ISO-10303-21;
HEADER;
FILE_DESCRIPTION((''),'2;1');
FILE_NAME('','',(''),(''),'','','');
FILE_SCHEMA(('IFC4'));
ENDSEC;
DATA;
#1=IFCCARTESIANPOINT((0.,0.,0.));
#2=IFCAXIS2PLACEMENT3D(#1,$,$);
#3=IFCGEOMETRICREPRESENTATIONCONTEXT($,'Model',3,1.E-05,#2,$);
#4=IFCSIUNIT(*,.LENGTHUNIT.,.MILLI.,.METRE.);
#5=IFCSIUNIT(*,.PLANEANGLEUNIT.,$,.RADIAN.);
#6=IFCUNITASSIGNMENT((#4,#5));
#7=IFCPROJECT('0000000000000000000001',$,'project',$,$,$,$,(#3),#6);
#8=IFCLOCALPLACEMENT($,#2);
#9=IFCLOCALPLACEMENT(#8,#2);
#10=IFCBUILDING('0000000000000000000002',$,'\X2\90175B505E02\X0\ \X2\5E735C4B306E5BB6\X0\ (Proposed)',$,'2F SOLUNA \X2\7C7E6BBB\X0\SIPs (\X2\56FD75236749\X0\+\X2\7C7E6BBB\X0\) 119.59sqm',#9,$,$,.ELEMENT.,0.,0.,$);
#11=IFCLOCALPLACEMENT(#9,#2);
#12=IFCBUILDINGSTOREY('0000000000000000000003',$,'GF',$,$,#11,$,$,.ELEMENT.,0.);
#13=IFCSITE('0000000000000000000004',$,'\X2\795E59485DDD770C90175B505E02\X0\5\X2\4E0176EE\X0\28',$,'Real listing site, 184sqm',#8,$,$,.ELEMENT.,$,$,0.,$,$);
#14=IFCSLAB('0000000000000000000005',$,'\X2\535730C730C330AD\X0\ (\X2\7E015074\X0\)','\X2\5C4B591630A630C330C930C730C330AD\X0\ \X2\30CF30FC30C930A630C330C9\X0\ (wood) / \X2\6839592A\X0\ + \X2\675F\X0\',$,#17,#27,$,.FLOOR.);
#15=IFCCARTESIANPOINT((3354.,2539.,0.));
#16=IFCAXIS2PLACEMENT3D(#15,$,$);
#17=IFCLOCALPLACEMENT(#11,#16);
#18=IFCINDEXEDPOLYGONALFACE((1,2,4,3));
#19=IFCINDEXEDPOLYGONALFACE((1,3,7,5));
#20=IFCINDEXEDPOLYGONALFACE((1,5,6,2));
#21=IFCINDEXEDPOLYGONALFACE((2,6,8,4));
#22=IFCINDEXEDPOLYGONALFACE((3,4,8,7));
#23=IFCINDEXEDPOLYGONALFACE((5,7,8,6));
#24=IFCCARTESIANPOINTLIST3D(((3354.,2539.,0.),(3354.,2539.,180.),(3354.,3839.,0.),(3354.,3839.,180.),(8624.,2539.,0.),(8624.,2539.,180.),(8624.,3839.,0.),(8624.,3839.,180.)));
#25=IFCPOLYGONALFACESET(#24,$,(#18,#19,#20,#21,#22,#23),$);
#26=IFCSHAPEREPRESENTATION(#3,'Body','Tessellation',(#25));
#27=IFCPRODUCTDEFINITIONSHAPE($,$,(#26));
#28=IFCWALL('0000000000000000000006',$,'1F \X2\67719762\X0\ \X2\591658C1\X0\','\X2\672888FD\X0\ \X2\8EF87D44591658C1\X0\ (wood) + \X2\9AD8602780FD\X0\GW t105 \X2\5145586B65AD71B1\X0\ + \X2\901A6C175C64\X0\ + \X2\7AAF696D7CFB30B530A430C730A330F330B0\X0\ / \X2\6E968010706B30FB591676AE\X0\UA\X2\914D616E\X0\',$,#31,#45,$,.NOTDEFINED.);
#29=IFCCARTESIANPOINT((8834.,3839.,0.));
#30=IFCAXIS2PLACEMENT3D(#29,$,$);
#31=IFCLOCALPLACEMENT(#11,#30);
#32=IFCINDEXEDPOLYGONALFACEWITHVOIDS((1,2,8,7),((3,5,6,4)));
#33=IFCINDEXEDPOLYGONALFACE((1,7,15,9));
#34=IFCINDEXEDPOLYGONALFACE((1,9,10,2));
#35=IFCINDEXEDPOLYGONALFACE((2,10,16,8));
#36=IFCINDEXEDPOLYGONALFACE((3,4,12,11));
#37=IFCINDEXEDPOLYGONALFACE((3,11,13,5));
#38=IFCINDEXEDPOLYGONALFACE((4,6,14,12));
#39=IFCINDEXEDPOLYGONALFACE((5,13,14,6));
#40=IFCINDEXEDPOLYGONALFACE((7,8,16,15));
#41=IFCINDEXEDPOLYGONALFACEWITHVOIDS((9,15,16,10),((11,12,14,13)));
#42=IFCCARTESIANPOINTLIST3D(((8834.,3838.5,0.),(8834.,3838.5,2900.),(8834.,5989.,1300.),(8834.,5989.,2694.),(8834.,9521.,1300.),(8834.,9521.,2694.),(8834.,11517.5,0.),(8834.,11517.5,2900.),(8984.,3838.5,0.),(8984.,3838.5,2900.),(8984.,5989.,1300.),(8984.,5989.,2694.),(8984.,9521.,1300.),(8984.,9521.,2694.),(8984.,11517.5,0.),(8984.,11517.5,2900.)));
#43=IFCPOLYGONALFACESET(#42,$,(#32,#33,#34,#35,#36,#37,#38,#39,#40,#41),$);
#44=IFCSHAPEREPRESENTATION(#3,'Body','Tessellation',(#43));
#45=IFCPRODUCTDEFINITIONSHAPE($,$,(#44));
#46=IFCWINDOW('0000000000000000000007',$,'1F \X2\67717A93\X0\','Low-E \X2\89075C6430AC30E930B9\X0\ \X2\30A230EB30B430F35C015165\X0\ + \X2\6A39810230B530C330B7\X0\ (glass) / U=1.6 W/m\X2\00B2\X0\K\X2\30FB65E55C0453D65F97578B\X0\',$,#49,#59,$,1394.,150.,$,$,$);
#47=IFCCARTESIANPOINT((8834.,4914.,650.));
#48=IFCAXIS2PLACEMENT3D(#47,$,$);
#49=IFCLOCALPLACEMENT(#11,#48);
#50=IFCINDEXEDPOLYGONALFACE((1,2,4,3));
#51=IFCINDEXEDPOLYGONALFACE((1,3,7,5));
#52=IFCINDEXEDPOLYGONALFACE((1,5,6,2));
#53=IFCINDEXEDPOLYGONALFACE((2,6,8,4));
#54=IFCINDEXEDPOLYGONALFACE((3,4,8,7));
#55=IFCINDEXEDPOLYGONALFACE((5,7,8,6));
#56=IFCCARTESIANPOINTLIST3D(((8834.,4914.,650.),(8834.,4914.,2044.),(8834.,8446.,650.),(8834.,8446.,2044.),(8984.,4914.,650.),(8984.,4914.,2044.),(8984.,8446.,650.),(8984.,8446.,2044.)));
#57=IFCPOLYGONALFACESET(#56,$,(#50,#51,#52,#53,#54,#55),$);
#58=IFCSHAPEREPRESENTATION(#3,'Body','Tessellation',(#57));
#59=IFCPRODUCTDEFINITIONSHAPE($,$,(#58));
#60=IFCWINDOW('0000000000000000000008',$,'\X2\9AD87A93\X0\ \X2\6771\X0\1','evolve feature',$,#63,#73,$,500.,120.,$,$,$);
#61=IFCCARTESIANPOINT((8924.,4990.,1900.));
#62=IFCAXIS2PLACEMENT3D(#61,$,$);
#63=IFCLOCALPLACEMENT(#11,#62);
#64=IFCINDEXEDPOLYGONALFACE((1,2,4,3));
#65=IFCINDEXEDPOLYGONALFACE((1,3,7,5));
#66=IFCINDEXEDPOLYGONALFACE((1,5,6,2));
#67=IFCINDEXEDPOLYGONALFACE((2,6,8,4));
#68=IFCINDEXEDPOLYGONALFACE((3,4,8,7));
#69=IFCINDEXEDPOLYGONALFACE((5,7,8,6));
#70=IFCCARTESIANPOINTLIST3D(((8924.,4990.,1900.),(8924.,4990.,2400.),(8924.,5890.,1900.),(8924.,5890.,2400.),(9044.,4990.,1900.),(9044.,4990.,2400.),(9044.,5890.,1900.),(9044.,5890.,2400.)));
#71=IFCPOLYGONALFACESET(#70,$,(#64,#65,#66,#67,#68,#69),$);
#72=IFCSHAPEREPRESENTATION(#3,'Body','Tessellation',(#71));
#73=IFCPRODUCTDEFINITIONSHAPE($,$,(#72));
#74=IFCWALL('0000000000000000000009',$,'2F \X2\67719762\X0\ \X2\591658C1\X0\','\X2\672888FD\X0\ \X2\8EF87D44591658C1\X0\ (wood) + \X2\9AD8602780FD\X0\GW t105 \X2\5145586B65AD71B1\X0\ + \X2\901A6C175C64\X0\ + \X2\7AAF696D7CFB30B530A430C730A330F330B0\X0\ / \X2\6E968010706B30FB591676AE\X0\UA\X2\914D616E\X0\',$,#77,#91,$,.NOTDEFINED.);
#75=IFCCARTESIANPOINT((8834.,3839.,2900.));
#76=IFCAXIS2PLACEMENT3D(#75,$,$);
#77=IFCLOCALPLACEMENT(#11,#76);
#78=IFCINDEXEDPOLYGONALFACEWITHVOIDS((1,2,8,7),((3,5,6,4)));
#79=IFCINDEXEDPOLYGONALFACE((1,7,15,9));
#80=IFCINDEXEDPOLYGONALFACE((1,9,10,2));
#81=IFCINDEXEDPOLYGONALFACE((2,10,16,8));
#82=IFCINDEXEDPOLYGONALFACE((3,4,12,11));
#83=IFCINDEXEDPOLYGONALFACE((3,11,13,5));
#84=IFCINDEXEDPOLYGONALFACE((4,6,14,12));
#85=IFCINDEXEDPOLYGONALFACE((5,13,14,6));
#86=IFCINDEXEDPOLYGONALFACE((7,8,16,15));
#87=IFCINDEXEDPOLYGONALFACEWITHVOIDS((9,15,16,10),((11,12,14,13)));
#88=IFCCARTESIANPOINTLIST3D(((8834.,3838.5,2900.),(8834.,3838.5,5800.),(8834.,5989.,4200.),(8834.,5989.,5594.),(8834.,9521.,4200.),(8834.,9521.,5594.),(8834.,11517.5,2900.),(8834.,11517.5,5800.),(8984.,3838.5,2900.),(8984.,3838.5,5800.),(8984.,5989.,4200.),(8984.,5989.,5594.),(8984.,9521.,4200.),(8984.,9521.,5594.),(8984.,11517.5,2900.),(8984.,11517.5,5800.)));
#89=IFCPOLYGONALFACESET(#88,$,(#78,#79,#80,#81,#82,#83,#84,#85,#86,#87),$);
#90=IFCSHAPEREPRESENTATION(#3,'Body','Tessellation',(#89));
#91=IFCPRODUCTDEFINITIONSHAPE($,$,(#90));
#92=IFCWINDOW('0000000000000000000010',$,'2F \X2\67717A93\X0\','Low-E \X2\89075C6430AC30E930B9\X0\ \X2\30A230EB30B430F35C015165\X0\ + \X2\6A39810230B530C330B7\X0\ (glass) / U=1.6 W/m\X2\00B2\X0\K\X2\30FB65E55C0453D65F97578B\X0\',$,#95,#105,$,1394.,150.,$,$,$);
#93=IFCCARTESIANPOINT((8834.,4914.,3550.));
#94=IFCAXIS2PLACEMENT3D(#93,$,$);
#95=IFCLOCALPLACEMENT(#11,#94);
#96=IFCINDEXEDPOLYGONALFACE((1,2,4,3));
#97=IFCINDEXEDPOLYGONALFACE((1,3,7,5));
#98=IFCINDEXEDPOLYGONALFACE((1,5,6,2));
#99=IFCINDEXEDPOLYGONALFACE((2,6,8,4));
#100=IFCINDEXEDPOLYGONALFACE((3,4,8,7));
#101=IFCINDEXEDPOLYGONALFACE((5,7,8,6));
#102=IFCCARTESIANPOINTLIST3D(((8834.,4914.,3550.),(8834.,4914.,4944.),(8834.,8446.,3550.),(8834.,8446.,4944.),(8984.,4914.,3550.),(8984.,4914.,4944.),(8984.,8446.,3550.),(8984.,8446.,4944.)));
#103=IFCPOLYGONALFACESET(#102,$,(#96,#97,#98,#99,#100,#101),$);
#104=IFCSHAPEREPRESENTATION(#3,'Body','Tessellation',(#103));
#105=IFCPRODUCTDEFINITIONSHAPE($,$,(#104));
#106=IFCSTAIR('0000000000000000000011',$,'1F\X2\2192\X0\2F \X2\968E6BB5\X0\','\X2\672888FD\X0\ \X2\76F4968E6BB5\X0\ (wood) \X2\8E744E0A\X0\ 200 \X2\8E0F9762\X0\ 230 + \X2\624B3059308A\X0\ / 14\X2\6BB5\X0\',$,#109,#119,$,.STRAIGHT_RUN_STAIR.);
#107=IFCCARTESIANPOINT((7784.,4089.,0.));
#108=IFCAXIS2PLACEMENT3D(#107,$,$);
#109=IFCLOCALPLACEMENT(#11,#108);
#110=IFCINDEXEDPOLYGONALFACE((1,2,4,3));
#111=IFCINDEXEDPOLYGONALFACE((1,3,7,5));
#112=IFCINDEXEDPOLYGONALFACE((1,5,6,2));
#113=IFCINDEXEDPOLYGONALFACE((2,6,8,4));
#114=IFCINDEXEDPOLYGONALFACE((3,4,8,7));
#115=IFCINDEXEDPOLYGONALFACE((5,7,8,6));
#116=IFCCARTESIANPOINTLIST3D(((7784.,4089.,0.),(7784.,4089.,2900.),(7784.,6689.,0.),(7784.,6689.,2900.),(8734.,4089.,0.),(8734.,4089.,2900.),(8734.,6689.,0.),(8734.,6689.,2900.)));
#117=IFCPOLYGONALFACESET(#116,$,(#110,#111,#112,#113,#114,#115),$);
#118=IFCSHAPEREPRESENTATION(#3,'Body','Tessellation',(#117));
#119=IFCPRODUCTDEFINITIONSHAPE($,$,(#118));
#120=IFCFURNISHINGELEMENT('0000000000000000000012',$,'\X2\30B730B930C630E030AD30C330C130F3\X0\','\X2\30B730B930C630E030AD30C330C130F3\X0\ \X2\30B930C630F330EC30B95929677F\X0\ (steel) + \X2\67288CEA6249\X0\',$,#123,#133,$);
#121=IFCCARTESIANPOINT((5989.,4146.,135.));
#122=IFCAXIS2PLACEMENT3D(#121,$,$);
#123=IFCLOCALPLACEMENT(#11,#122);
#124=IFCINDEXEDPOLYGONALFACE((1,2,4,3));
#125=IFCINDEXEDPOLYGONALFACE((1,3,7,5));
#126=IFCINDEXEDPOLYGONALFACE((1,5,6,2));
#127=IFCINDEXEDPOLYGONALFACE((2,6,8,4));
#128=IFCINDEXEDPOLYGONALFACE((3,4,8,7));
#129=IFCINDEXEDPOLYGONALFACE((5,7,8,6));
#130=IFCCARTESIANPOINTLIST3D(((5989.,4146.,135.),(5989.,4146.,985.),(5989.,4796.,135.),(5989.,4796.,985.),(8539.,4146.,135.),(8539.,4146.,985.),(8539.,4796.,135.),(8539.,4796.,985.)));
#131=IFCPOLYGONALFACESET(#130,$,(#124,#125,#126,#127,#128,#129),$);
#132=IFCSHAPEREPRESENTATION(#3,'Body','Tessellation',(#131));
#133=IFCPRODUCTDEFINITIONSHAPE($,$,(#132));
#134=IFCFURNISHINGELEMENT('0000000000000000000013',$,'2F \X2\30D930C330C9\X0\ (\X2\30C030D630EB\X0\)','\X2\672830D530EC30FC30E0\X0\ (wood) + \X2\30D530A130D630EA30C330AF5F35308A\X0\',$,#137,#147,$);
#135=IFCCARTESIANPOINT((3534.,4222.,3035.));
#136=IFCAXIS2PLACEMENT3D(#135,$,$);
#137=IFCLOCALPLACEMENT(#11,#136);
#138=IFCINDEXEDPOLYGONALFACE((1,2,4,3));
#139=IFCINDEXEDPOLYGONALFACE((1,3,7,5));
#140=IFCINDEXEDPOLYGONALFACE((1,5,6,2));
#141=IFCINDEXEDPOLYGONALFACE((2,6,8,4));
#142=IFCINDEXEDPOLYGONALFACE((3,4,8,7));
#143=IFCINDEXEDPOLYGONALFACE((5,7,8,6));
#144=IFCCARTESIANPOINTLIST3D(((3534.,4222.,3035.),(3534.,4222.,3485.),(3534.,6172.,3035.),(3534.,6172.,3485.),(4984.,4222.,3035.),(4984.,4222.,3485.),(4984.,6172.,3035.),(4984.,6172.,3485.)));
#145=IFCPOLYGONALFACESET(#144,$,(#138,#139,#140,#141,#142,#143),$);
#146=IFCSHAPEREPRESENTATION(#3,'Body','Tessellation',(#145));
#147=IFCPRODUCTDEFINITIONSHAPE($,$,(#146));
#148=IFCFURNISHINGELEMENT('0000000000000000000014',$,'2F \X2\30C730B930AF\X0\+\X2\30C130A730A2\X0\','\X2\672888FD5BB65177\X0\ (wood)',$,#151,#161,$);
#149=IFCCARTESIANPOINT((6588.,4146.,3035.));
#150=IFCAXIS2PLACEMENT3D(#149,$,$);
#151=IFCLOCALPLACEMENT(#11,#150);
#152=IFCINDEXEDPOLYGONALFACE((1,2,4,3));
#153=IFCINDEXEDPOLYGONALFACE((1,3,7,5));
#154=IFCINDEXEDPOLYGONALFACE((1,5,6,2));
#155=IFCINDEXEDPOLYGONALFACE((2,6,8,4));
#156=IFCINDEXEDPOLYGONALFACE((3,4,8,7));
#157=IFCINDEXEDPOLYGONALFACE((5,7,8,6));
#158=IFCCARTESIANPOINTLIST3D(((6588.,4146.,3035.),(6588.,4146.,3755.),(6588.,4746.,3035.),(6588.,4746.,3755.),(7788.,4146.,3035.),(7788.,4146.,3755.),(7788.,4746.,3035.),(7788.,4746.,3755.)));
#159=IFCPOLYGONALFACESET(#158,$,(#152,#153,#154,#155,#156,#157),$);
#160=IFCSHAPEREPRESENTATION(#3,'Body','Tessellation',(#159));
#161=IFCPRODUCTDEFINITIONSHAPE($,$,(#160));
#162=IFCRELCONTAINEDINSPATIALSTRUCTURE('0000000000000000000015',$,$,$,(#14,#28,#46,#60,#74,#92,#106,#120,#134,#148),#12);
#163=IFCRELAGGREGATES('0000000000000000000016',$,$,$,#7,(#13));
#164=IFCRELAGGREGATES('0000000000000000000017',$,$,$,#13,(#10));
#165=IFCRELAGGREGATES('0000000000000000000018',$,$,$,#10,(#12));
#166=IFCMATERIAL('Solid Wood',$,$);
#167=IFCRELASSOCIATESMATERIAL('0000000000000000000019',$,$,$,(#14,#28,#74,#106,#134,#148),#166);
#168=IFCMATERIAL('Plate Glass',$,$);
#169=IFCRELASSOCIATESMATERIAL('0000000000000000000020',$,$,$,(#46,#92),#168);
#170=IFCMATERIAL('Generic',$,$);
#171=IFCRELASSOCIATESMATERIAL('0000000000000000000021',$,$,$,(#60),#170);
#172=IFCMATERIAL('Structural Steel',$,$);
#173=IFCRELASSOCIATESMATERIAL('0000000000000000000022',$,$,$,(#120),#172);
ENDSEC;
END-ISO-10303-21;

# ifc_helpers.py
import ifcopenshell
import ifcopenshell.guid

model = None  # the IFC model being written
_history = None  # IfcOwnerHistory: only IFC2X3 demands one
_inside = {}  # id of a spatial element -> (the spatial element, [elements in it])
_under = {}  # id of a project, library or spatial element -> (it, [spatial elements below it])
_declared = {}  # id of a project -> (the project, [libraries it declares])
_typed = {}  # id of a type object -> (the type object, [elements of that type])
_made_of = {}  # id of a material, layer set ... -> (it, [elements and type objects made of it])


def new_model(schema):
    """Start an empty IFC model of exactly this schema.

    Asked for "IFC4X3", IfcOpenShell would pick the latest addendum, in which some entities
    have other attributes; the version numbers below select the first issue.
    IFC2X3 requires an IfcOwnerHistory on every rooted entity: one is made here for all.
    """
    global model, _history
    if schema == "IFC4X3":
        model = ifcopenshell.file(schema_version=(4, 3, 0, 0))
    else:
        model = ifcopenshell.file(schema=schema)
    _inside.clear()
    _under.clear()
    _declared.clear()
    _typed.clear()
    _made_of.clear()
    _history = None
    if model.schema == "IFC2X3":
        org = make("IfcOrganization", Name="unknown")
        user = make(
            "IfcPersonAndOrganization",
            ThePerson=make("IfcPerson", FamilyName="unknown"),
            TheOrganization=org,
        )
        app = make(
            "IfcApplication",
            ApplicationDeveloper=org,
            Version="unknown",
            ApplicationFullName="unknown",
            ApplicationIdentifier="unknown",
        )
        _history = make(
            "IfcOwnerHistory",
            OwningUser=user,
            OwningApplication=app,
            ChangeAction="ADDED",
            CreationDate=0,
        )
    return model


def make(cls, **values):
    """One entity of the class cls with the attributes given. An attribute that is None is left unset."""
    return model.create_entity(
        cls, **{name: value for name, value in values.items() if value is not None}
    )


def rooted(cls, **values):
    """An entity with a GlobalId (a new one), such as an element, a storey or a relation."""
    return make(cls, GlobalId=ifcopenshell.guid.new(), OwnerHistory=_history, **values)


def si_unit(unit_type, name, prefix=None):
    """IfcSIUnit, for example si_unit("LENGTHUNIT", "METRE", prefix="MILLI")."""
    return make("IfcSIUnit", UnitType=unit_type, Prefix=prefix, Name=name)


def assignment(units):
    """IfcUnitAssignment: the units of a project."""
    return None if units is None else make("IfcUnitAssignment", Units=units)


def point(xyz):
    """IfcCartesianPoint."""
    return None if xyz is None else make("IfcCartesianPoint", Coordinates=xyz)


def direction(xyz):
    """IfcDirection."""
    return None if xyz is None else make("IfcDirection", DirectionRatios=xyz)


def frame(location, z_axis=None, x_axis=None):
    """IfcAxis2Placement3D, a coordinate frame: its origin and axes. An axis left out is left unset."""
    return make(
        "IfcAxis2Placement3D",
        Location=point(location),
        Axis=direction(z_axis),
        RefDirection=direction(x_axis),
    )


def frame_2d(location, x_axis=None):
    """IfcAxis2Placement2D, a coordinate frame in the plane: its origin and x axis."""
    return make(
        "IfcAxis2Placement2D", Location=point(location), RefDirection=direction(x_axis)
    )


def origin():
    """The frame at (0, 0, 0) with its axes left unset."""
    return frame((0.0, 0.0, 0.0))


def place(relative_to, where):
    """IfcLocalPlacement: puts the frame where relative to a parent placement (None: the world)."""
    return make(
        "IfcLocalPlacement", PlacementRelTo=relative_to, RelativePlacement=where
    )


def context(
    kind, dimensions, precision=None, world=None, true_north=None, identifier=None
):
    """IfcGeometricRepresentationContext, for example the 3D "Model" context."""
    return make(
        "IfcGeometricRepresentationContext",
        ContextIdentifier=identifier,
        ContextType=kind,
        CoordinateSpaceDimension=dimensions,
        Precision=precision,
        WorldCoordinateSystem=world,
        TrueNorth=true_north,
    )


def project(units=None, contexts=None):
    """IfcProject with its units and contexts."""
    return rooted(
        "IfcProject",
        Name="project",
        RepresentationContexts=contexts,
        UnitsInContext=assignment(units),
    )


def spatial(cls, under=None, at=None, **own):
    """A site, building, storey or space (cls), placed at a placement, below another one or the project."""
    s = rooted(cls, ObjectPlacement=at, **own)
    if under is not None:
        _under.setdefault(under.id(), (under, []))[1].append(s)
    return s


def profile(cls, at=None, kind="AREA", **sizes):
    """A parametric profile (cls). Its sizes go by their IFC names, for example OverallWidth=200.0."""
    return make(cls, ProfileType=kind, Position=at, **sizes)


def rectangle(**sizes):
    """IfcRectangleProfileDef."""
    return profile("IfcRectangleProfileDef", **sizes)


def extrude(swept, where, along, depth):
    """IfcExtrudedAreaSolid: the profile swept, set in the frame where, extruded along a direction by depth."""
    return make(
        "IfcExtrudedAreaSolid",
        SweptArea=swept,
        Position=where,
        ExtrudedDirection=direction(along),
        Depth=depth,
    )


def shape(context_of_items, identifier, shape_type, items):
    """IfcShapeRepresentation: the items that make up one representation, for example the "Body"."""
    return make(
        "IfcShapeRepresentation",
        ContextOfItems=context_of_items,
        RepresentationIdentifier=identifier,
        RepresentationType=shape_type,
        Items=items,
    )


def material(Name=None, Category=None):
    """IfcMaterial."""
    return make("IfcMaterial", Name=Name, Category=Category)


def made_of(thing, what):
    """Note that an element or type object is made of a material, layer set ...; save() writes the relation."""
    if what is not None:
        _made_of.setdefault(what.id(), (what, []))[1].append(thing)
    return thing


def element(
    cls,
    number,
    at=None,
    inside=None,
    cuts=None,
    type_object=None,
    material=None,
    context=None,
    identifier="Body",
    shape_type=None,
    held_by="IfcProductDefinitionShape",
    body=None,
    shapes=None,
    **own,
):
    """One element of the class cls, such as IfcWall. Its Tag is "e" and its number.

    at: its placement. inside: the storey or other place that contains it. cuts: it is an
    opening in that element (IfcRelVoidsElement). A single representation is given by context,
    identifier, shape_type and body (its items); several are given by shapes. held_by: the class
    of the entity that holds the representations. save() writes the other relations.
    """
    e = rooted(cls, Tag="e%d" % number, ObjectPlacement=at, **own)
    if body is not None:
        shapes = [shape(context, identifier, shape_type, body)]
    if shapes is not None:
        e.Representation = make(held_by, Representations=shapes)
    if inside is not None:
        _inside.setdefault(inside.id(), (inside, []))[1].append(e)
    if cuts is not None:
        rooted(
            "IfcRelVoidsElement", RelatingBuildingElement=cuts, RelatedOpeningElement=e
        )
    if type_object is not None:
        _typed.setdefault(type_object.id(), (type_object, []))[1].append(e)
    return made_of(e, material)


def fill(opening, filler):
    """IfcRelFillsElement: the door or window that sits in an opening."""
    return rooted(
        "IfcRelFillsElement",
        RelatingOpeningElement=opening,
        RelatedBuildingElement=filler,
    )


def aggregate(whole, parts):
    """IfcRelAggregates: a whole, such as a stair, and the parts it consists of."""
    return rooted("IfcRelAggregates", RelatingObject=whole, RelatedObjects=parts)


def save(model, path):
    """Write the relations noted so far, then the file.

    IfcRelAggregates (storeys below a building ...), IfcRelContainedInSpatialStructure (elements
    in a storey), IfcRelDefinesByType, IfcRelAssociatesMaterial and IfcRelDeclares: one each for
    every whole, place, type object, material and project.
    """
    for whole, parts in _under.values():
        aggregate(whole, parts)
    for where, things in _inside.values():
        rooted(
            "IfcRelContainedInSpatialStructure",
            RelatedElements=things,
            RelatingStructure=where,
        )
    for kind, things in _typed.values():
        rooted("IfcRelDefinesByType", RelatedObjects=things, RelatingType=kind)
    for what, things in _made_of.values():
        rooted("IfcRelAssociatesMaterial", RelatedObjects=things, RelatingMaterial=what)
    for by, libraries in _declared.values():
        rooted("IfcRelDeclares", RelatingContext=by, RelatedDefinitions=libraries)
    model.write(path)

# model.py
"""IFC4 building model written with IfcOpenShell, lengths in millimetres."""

from ifc_helpers import new_model, si_unit, frame, frame_2d, origin, place, context, project, spatial, rectangle, extrude, material, element, fill, save


model = new_model("IFC4")

# Units and contexts
model_context = context("Model", 3, precision=1e-05, world=origin())
ifc_project = project(units=[si_unit("LENGTHUNIT", "METRE", prefix="MILLI"), si_unit("PLANEANGLEUNIT", "RADIAN")], contexts=[model_context])

# Site, building, storey
site_placement = place(None, origin())
site = spatial("IfcSite", under=ifc_project, at=site_placement, Name="神奈川県逗子市5丁目28", ObjectType="Real listing site, 184sqm", CompositionType="ELEMENT", RefElevation=0.0)
building_placement = place(site_placement, origin())
building = spatial("IfcBuilding", under=site, at=building_placement, Name="逗子市 平屋の家 (Proposed)", ObjectType="2F SOLUNA 籾殻SIPs (国産杉+籾殻) 119.59sqm", CompositionType="ELEMENT", ElevationOfRefHeight=0.0, ElevationOfTerrain=0.0)
storey_placement = place(building_placement, origin())
storey = spatial("IfcBuildingStorey", under=building, at=storey_placement, Name="GF", CompositionType="ELEMENT", Elevation=0.0)

# Slab
ifc_material_1 = material(Name="Solid Wood")
slab_placement = place(storey_placement, frame((3354.0, 2539.0, 0.0)))
element("IfcSlab", 1, at=slab_placement, inside=storey, material=ifc_material_1, Name="南デッキ (縁側)", Description="屋外ウッドデッキ ハードウッド (wood) / 根太 + 束", PredefinedType="FLOOR", context=model_context, shape_type="SweptSolid", body=[
    extrude(rectangle(XDim=5270.0, YDim=1300.0, at=frame_2d((2635.0, 650.0))), frame((3354.0, 2539.0, 0.0)), (0.0, 0.0, 1.0), 180.0),
])

# Wall, openings, windows
wall_1_placement = place(storey_placement, frame((8834.0, 3839.0, 0.0)))
wall_1 = element("IfcWall", 2, at=wall_1_placement, inside=storey, material=ifc_material_1, Name="1F 東面 外壁", Description="木製 軸組外壁 (wood) + 高性能GW t105 充填断熱 + 通気層 + 窯業系サイディング / 準耐火・外皮UA配慮", PredefinedType="NOTDEFINED", context=model_context, shape_type="SweptSolid", body=[
    extrude(rectangle(XDim=150.0, YDim=7679.0, at=frame_2d((75.0, 3839.0))), frame((8834.0, 3839.0, 0.0)), (0.0, 0.0, 1.0), 2900.0),
])
opening_1_placement = place(storey_placement, frame((8834.0, 4914.0, 650.0)))
opening_1 = element("IfcOpeningElement", 3, at=opening_1_placement, cuts=wall_1, PredefinedType="NOTDEFINED", context=model_context, shape_type="SweptSolid", body=[
    extrude(rectangle(XDim=150.0, YDim=3532.0, at=frame_2d((75.0, 1766.0))), frame((8834.0, 4914.0, 650.0)), (0.0, 0.0, 1.0), 1394.0),
])
opening_2_placement = place(storey_placement, frame((8924.0, 4990.0, 1900.0)))
opening_2 = element("IfcOpeningElement", 4, at=opening_2_placement, cuts=wall_1, PredefinedType="NOTDEFINED", context=model_context, shape_type="SweptSolid", body=[
    extrude(rectangle(XDim=120.0, YDim=900.0, at=frame_2d((60.0, 450.0))), frame((8924.0, 4990.0, 1900.0)), (0.0, 0.0, 1.0), 500.0),
])
ifc_material_2 = material(Name="Plate Glass")
window_1_placement = place(storey_placement, frame((8834.0, 4914.0, 650.0)))
window_1 = element("IfcWindow", 5, at=window_1_placement, inside=storey, material=ifc_material_2, Name="1F 東窓", Description="Low-E 複層ガラス アルゴン封入 + 樹脂サッシ (glass) / U=1.6 W/m²K・日射取得型", OverallHeight=1394.0, OverallWidth=150.0, context=model_context, shape_type="SweptSolid", body=[
    extrude(rectangle(XDim=150.0, YDim=3532.0, at=frame_2d((75.0, 1766.0))), frame((8834.0, 4914.0, 650.0)), (0.0, 0.0, 1.0), 1394.0),
])
fill(opening_1, window_1)
ifc_material_3 = material(Name="Generic")
window_2_placement = place(storey_placement, frame((8924.0, 4990.0, 1900.0)))
window_2 = element("IfcWindow", 6, at=window_2_placement, inside=storey, material=ifc_material_3, Name="高窓 東1", Description="evolve feature", OverallHeight=500.0, OverallWidth=120.0, context=model_context, shape_type="SweptSolid", body=[
    extrude(rectangle(XDim=120.0, YDim=900.0, at=frame_2d((60.0, 450.0))), frame((8924.0, 4990.0, 1900.0)), (0.0, 0.0, 1.0), 500.0),
])
fill(opening_2, window_2)

# Wall, opening, window
wall_2_placement = place(storey_placement, frame((8834.0, 3839.0, 2900.0)))
wall_2 = element("IfcWall", 7, at=wall_2_placement, inside=storey, material=ifc_material_1, Name="2F 東面 外壁", Description="木製 軸組外壁 (wood) + 高性能GW t105 充填断熱 + 通気層 + 窯業系サイディング / 準耐火・外皮UA配慮", PredefinedType="NOTDEFINED", context=model_context, shape_type="SweptSolid", body=[
    extrude(rectangle(XDim=150.0, YDim=7679.0, at=frame_2d((75.0, 3839.0))), frame((8834.0, 3839.0, 2900.0)), (0.0, 0.0, 1.0), 2900.0),
])
opening_3_placement = place(storey_placement, frame((8834.0, 4914.0, 3550.0)))
opening_3 = element("IfcOpeningElement", 8, at=opening_3_placement, cuts=wall_2, PredefinedType="NOTDEFINED", context=model_context, shape_type="SweptSolid", body=[
    extrude(rectangle(XDim=150.0, YDim=3532.0, at=frame_2d((75.0, 1766.0))), frame((8834.0, 4914.0, 3550.0)), (0.0, 0.0, 1.0), 1394.0),
])
window_3_placement = place(storey_placement, frame((8834.0, 4914.0, 3550.0)))
window_3 = element("IfcWindow", 9, at=window_3_placement, inside=storey, material=ifc_material_2, Name="2F 東窓", Description="Low-E 複層ガラス アルゴン封入 + 樹脂サッシ (glass) / U=1.6 W/m²K・日射取得型", OverallHeight=1394.0, OverallWidth=150.0, context=model_context, shape_type="SweptSolid", body=[
    extrude(rectangle(XDim=150.0, YDim=3532.0, at=frame_2d((75.0, 1766.0))), frame((8834.0, 4914.0, 3550.0)), (0.0, 0.0, 1.0), 1394.0),
])
fill(opening_3, window_3)

# Stair
stair_placement = place(storey_placement, frame((7784.0, 4089.0, 0.0)))
element("IfcStair", 10, at=stair_placement, inside=storey, material=ifc_material_1, Name="1F→2F 階段", Description="木製 直階段 (wood) 蹴上 200 踏面 230 + 手すり / 14段", PredefinedType="STRAIGHT_RUN_STAIR", context=model_context, shape_type="SweptSolid", body=[
    extrude(rectangle(XDim=950.0, YDim=2600.0, at=frame_2d((475.0, 1300.0))), frame((7784.0, 4089.0, 0.0)), (0.0, 0.0, 1.0), 2900.0),
])

# Furnishing elements
ifc_material_4 = material(Name="Structural Steel")
furnishing_1_placement = place(storey_placement, frame((5989.0, 4146.0, 135.0)))
element("IfcFurnishingElement", 11, at=furnishing_1_placement, inside=storey, material=ifc_material_4, Name="システムキッチン", Description="システムキッチン ステンレス天板 (steel) + 木質扉", context=model_context, shape_type="SweptSolid", body=[
    extrude(rectangle(XDim=2550.0, YDim=650.0, at=frame_2d((1275.0, 325.0))), frame((5989.0, 4146.0, 135.0)), (0.0, 0.0, 1.0), 850.0),
])
furnishing_2_placement = place(storey_placement, frame((3534.0, 4222.0, 3035.0)))
element("IfcFurnishingElement", 12, at=furnishing_2_placement, inside=storey, material=ifc_material_1, Name="2F ベッド (ダブル)", Description="木フレーム (wood) + ファブリック張り", context=model_context, shape_type="SweptSolid", body=[
    extrude(rectangle(XDim=1450.0, YDim=1950.0, at=frame_2d((725.0, 975.0))), frame((3534.0, 4222.0, 3035.0)), (0.0, 0.0, 1.0), 450.0),
])
furnishing_3_placement = place(storey_placement, frame((6588.0, 4146.0, 3035.0)))
element("IfcFurnishingElement", 13, at=furnishing_3_placement, inside=storey, material=ifc_material_1, Name="2F デスク+チェア", Description="木製家具 (wood)", context=model_context, shape_type="SweptSolid", body=[
    extrude(rectangle(XDim=1200.0, YDim=600.0, at=frame_2d((600.0, 300.0))), frame((6588.0, 4146.0, 3035.0)), (0.0, 0.0, 1.0), 720.0),
])

save(model, "model.ifc")
